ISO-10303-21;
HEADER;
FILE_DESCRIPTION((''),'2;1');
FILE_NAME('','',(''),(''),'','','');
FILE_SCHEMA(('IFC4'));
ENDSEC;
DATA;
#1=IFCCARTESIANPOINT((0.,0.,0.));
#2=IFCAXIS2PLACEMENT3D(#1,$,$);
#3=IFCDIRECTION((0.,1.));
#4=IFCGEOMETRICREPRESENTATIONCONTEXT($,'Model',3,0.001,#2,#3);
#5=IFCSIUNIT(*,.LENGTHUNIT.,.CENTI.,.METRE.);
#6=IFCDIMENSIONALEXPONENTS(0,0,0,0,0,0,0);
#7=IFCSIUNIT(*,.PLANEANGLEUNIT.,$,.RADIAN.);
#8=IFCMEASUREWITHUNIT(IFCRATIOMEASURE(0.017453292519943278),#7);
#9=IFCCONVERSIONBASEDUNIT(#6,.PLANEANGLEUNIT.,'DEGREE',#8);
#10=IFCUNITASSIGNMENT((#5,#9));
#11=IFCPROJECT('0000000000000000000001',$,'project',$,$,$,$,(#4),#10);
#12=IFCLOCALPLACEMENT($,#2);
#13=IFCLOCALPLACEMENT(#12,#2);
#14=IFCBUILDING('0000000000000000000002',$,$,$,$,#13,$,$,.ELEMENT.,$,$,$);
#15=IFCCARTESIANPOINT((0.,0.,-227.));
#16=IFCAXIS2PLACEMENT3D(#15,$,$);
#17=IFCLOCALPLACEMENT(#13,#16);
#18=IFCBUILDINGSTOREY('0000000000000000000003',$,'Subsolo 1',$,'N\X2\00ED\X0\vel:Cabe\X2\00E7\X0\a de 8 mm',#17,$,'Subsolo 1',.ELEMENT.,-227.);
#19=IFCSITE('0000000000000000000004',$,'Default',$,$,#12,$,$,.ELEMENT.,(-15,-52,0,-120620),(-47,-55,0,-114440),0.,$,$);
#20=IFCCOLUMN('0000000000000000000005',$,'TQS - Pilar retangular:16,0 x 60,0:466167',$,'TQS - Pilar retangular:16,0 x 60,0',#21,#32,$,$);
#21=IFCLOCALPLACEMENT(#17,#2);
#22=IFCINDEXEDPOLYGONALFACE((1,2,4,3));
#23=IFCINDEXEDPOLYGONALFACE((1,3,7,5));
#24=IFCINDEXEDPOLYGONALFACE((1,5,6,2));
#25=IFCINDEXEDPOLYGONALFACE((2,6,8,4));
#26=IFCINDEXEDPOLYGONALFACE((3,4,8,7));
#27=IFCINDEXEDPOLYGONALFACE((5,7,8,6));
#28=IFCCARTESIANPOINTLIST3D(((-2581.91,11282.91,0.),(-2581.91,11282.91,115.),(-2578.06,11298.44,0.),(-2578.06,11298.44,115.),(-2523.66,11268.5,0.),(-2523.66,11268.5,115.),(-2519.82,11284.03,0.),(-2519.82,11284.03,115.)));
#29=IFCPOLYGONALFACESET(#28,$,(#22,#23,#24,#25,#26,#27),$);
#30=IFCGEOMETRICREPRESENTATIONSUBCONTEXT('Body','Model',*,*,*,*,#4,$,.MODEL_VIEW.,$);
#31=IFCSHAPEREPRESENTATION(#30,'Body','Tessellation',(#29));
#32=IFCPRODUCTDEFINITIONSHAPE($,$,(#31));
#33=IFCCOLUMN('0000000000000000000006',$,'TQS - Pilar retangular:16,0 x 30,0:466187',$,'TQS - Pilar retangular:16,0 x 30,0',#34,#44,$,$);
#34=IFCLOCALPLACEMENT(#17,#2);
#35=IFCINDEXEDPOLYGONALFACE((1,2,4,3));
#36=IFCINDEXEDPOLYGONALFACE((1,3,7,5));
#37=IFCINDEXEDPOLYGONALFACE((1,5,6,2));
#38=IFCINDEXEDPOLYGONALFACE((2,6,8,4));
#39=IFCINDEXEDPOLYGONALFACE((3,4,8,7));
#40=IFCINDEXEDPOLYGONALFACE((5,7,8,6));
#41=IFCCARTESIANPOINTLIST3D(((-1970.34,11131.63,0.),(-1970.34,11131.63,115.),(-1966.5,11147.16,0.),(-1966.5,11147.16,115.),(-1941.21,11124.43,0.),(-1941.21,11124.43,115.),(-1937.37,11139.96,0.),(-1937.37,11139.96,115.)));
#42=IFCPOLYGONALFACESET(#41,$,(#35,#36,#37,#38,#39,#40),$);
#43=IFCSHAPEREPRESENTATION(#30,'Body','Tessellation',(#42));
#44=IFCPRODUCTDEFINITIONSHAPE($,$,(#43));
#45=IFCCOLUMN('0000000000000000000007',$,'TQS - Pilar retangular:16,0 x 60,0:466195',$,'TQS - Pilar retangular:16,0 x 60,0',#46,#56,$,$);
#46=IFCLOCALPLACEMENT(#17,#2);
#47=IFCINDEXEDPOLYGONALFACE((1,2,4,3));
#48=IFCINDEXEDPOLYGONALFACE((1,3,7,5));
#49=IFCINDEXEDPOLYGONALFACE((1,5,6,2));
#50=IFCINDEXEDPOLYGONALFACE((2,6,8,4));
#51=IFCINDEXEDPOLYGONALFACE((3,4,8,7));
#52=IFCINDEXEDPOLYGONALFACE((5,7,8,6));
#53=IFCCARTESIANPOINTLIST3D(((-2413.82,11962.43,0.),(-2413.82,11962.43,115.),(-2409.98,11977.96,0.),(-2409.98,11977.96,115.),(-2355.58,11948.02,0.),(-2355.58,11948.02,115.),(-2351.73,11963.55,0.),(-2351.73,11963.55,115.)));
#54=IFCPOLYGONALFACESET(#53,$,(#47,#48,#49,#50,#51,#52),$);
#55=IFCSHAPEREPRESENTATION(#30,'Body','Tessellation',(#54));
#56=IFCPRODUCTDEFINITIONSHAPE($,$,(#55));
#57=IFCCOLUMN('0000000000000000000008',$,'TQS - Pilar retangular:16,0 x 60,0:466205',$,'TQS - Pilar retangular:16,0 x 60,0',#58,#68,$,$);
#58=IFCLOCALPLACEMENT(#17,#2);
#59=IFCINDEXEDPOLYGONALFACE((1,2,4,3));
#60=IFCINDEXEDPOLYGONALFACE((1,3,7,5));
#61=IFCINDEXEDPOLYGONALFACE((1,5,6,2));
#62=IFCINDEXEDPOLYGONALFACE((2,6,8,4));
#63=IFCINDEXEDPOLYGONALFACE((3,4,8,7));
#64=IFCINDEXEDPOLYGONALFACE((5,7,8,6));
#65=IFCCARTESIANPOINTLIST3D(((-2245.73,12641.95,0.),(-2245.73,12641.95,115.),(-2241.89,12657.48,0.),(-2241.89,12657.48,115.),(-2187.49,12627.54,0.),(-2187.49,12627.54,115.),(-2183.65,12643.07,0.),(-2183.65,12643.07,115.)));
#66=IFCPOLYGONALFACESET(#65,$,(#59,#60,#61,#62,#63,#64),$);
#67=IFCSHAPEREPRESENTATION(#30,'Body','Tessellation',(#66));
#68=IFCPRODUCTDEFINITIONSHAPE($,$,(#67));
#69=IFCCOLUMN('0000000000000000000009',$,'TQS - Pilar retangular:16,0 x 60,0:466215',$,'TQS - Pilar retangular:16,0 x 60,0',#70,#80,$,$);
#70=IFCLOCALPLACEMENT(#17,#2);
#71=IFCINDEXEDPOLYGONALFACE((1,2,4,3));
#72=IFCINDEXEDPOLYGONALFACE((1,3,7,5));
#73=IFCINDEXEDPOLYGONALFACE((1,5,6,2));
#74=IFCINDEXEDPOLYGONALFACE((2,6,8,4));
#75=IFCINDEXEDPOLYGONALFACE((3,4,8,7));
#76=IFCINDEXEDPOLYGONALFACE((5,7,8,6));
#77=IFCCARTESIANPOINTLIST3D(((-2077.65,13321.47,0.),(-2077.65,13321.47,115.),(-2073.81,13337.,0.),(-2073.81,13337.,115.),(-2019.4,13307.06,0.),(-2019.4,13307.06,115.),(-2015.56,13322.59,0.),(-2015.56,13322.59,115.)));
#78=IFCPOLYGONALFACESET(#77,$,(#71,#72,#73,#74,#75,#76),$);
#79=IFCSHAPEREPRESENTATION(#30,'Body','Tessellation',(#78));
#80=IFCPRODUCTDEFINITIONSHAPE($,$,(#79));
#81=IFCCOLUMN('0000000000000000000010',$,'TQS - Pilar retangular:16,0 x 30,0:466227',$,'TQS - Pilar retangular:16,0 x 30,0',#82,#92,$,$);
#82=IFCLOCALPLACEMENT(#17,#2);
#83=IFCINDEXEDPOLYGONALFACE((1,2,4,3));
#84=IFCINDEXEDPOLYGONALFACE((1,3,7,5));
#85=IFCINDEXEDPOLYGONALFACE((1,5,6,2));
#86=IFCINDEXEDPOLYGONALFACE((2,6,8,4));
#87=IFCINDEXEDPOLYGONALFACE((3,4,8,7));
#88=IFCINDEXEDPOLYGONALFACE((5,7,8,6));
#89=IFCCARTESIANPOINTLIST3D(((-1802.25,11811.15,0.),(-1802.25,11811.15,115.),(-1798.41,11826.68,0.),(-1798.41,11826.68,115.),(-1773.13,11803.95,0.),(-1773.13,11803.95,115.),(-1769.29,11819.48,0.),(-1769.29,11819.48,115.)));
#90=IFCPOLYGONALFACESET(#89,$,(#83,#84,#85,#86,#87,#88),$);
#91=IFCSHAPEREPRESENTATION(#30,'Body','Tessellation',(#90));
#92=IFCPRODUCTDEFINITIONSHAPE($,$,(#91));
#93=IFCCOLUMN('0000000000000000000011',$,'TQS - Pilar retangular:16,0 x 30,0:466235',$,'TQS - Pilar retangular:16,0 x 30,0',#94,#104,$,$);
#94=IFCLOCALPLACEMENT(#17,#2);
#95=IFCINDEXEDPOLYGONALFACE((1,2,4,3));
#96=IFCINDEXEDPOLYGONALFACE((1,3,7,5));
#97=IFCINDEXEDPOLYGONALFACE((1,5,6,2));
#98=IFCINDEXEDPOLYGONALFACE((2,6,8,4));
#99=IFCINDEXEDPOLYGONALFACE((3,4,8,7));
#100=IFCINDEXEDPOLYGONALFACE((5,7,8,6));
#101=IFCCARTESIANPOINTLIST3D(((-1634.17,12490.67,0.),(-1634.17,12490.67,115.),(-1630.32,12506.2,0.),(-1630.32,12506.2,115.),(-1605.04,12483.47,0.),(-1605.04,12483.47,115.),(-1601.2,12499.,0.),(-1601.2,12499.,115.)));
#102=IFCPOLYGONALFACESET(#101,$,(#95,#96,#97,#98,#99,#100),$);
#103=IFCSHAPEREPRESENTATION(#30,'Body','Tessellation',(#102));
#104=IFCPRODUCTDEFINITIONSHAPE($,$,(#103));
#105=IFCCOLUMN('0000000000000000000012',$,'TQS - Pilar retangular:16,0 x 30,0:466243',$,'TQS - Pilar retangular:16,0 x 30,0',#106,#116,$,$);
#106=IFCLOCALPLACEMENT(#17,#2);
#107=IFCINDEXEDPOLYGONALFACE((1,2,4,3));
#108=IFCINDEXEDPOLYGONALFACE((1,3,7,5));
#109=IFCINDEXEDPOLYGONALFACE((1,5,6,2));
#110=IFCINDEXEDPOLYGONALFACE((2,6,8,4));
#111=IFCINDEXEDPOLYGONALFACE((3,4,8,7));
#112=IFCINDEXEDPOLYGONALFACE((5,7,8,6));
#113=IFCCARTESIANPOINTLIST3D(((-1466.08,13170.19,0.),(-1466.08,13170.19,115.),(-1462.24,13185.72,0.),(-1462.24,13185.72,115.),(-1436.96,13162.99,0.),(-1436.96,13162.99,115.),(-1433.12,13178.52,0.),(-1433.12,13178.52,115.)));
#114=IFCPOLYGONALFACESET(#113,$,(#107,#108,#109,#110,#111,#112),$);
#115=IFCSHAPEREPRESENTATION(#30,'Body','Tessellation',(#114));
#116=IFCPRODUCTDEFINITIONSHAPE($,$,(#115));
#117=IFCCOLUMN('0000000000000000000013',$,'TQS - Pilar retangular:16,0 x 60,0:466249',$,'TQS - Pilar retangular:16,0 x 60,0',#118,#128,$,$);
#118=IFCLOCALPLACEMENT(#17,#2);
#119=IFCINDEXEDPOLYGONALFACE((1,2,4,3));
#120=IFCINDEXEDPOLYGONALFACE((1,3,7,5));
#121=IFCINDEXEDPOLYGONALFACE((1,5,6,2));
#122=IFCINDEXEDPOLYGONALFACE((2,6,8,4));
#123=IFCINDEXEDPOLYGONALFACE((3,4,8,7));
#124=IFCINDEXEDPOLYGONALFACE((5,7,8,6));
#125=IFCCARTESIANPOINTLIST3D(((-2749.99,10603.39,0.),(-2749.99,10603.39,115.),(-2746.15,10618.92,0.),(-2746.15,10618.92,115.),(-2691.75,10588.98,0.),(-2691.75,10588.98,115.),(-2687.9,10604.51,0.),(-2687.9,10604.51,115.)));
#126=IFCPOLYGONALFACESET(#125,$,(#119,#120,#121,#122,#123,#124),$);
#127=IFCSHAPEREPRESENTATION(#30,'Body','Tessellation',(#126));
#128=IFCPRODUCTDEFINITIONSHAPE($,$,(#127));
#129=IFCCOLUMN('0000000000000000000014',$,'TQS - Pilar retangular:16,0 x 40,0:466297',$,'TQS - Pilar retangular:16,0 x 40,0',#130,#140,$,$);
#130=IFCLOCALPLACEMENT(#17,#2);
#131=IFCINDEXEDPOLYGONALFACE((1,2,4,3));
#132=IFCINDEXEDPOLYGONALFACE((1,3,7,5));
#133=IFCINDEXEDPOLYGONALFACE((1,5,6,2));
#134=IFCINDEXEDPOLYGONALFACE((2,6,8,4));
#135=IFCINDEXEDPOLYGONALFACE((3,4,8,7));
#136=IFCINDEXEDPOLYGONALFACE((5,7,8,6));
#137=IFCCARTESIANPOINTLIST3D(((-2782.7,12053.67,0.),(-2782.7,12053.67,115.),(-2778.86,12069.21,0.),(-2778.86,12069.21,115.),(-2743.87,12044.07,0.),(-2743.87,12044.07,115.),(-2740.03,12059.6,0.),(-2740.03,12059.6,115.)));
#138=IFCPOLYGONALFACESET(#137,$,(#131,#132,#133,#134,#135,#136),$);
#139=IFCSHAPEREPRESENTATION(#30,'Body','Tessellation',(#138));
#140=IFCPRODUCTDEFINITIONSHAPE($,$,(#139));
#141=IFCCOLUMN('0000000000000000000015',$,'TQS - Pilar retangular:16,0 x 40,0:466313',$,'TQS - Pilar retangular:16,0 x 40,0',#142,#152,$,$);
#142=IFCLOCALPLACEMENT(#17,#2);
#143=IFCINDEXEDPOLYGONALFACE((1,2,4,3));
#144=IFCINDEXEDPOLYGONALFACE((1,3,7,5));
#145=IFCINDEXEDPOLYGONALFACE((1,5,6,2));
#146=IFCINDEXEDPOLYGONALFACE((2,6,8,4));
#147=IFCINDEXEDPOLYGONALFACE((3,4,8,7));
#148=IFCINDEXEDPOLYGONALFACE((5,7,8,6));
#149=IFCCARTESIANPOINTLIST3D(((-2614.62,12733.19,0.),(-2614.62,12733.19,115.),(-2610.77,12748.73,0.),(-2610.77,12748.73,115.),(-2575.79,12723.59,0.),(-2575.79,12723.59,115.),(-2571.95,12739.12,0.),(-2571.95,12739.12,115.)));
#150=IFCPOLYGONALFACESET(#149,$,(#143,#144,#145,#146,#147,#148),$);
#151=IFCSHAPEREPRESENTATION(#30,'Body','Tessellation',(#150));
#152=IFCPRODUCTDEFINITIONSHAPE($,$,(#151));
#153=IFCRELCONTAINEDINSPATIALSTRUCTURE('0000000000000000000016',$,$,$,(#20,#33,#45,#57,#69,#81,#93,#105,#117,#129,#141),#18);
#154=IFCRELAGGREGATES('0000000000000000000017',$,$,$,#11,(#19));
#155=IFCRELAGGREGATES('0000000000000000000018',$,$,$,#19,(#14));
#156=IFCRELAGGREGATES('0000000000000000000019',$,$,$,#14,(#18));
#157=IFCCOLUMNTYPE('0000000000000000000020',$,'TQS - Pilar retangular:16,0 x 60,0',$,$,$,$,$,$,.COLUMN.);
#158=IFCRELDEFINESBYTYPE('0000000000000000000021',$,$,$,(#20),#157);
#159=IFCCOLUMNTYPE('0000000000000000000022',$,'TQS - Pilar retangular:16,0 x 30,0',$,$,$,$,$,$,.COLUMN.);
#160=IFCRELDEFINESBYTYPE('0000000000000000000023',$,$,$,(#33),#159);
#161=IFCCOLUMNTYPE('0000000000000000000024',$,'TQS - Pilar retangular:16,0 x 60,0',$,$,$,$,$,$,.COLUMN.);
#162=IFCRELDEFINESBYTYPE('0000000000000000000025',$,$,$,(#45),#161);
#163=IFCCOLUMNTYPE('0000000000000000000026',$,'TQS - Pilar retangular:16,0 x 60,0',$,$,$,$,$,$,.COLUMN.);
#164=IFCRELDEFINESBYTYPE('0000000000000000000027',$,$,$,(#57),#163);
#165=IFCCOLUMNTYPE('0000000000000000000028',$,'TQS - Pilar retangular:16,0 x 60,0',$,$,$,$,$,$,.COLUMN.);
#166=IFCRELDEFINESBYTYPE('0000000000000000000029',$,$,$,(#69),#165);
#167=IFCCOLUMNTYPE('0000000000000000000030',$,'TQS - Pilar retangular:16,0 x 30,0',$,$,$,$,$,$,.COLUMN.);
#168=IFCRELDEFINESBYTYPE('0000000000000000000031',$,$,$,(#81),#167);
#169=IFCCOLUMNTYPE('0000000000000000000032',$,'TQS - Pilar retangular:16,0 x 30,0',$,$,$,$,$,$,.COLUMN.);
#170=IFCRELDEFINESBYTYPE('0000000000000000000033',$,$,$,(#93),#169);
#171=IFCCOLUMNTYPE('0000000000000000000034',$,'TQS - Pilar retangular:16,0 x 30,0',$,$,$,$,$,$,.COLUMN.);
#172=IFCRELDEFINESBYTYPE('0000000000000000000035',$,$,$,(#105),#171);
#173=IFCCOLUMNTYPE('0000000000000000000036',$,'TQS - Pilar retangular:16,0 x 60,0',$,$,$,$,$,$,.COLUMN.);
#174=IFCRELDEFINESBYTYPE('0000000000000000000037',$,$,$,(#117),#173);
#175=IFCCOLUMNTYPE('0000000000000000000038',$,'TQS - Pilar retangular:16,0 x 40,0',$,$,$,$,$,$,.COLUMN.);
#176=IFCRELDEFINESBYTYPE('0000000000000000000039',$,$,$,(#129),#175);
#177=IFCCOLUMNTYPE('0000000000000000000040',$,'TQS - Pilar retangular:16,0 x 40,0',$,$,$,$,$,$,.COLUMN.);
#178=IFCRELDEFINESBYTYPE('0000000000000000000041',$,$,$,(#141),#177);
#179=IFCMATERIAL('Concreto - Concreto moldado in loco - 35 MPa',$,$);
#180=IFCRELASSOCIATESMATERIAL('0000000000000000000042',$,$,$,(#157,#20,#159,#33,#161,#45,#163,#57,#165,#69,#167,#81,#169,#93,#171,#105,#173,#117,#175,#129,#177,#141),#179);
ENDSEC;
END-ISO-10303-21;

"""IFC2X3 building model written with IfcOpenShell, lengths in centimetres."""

from ifc_helpers import new_model, entity, si_unit, converted_unit, direction, frame, frame_2d, origin, origin_2d_with_axis, place, context, subcontext, project, spatial, rectangle, extrude, source, transform, mapped, material, type_object, type_shapes, element, save


model = new_model("IFC2X3")

# Units and contexts
model_context = context("Model", 3, precision=0.001, world=origin(), true_north=direction((0.0, 1.0)))
body_context = subcontext(model_context, "Body", "Model", "MODEL_VIEW")
ifc_project = project(units=[si_unit("LENGTHUNIT", "METRE", prefix="CENTI"), converted_unit("PLANEANGLEUNIT", "DEGREE", entity("IfcRatioMeasure", 0.017453292519943278), si_unit("PLANEANGLEUNIT", "RADIAN"), dimensions=[0, 0, 0, 0, 0, 0, 0])], contexts=[model_context])

# Site, building, storey
site_placement = place(None, origin())
site = spatial("IfcSite", under=ifc_project, at=site_placement, Name="Default", CompositionType="ELEMENT", RefLatitude=(-15, -52, 0, -120620), RefLongitude=(-47, -55, 0, -114440), RefElevation=0.0)
building_placement = place(site_placement, origin())
building = spatial("IfcBuilding", under=site, at=building_placement, CompositionType="ELEMENT")
storey_placement = place(building_placement, frame((0.0, 0.0, -227.0)))
storey = spatial("IfcBuildingStorey", under=building, at=storey_placement, Name="Subsolo 1", ObjectType="Nível:Cabeça de 8 mm", LongName="Subsolo 1", CompositionType="ELEMENT", Elevation=-227.0)

# Columns
ifc_material = material(Name="Concreto - Concreto moldado in loco - 35 MPa")
column_type_1 = type_object("IfcColumnType", Name="TQS - Pilar retangular:16,0 x 60,0", PredefinedType="COLUMN", material=ifc_material)
shared_shape_1 = source(origin(), body_context, "Body", "SweptSolid", [
    extrude(rectangle(XDim=60.0, YDim=16.0, at=origin_2d_with_axis()), frame((-2550.86, 11283.47, -227.0), z_axis=(0.0, 0.0, 1.0), x_axis=(-0.970743, 0.240122, 0.0)), (0.0, 0.0, 1.0), 115.0),
])
type_shapes(column_type_1, [shared_shape_1])
column_1_placement = place(storey_placement, frame((0.0, 0.0, 227.0)))
element("IfcColumn", 1, at=column_1_placement, inside=storey, type_object=column_type_1, material=ifc_material, Name="TQS - Pilar retangular:16,0 x 60,0:466167", ObjectType="TQS - Pilar retangular:16,0 x 60,0", context=body_context, shape_type="MappedRepresentation", body=[
    mapped(shared_shape_1, transform((0.0, 0.0, 0.0), scale=1.0)),
])
column_type_2 = type_object("IfcColumnType", Name="TQS - Pilar retangular:16,0 x 30,0", PredefinedType="COLUMN", material=ifc_material)
shared_shape_2 = source(origin(), body_context, "Body", "SweptSolid", [
    extrude(rectangle(XDim=30.0, YDim=16.0, at=frame_2d((0.0, 0.0), x_axis=(1.0, 0.0))), frame((-1953.86, 11135.79, -227.0), z_axis=(0.0, 0.0, 1.0), x_axis=(-0.970743, 0.240122, 0.0)), (0.0, 0.0, 1.0), 115.0),
])
type_shapes(column_type_2, [shared_shape_2])
column_2_placement = place(storey_placement, frame((0.0, 0.0, 227.0)))
element("IfcColumn", 2, at=column_2_placement, inside=storey, type_object=column_type_2, material=ifc_material, Name="TQS - Pilar retangular:16,0 x 30,0:466187", ObjectType="TQS - Pilar retangular:16,0 x 30,0", context=body_context, shape_type="MappedRepresentation", body=[
    mapped(shared_shape_2, transform((0.0, 0.0, 0.0), scale=1.0)),
])
column_type_3 = type_object("IfcColumnType", Name="TQS - Pilar retangular:16,0 x 60,0", PredefinedType="COLUMN", material=ifc_material)
shared_shape_3 = source(origin(), body_context, "Body", "SweptSolid", [
    extrude(rectangle(XDim=60.0, YDim=16.0, at=origin_2d_with_axis()), frame((-2382.78, 11962.99, -227.0), z_axis=(0.0, 0.0, 1.0), x_axis=(-0.970743, 0.240122, 0.0)), (0.0, 0.0, 1.0), 115.0),
])
type_shapes(column_type_3, [shared_shape_3])
column_3_placement = place(storey_placement, frame((0.0, 0.0, 227.0)))
element("IfcColumn", 3, at=column_3_placement, inside=storey, type_object=column_type_3, material=ifc_material, Name="TQS - Pilar retangular:16,0 x 60,0:466195", ObjectType="TQS - Pilar retangular:16,0 x 60,0", context=body_context, shape_type="MappedRepresentation", body=[
    mapped(shared_shape_3, transform((0.0, 0.0, 0.0), scale=1.0)),
])
column_type_4 = type_object("IfcColumnType", Name="TQS - Pilar retangular:16,0 x 60,0", PredefinedType="COLUMN", material=ifc_material)
shared_shape_4 = source(origin(), body_context, "Body", "SweptSolid", [
    extrude(rectangle(XDim=60.0, YDim=16.0, at=origin_2d_with_axis()), frame((-2214.69, 12642.51, -227.0), z_axis=(0.0, 0.0, 1.0), x_axis=(-0.970743, 0.240122, 0.0)), (0.0, 0.0, 1.0), 115.0),
])
type_shapes(column_type_4, [shared_shape_4])
column_4_placement = place(storey_placement, frame((0.0, 0.0, 227.0)))
element("IfcColumn", 4, at=column_4_placement, inside=storey, type_object=column_type_4, material=ifc_material, Name="TQS - Pilar retangular:16,0 x 60,0:466205", ObjectType="TQS - Pilar retangular:16,0 x 60,0", context=body_context, shape_type="MappedRepresentation", body=[
    mapped(shared_shape_4, transform((0.0, 0.0, 0.0), scale=1.0)),
])
column_type_5 = type_object("IfcColumnType", Name="TQS - Pilar retangular:16,0 x 60,0", PredefinedType="COLUMN", material=ifc_material)
shared_shape_5 = source(origin(), body_context, "Body", "SweptSolid", [
    extrude(rectangle(XDim=60.0, YDim=16.0, at=origin_2d_with_axis()), frame((-2046.61, 13322.03, -227.0), z_axis=(0.0, 0.0, 1.0), x_axis=(-0.970743, 0.240122, 0.0)), (0.0, 0.0, 1.0), 115.0),
])
type_shapes(column_type_5, [shared_shape_5])
column_5_placement = place(storey_placement, frame((0.0, 0.0, 227.0)))
element("IfcColumn", 5, at=column_5_placement, inside=storey, type_object=column_type_5, material=ifc_material, Name="TQS - Pilar retangular:16,0 x 60,0:466215", ObjectType="TQS - Pilar retangular:16,0 x 60,0", context=body_context, shape_type="MappedRepresentation", body=[
    mapped(shared_shape_5, transform((0.0, 0.0, 0.0), scale=1.0)),
])
column_type_6 = type_object("IfcColumnType", Name="TQS - Pilar retangular:16,0 x 30,0", PredefinedType="COLUMN", material=ifc_material)
shared_shape_6 = source(origin(), body_context, "Body", "SweptSolid", [
    extrude(rectangle(XDim=30.0, YDim=16.0, at=origin_2d_with_axis()), frame((-1785.77, 11815.31, -227.0), z_axis=(0.0, 0.0, 1.0), x_axis=(-0.970743, 0.240122, 0.0)), (0.0, 0.0, 1.0), 115.0),
])
type_shapes(column_type_6, [shared_shape_6])
column_6_placement = place(storey_placement, frame((0.0, 0.0, 227.0)))
element("IfcColumn", 6, at=column_6_placement, inside=storey, type_object=column_type_6, material=ifc_material, Name="TQS - Pilar retangular:16,0 x 30,0:466227", ObjectType="TQS - Pilar retangular:16,0 x 30,0", context=body_context, shape_type="MappedRepresentation", body=[
    mapped(shared_shape_6, transform((0.0, 0.0, 0.0), scale=1.0)),
])
column_type_7 = type_object("IfcColumnType", Name="TQS - Pilar retangular:16,0 x 30,0", PredefinedType="COLUMN", material=ifc_material)
shared_shape_7 = source(origin(), body_context, "Body", "SweptSolid", [
    extrude(rectangle(XDim=30.0, YDim=16.0, at=origin_2d_with_axis()), frame((0.0, 0.0, -227.0), z_axis=(0.0, 0.0, 1.0), x_axis=(0.0, -1.0, 0.0)), (0.0, 0.0, 1.0), 115.0),
])
type_shapes(column_type_7, [shared_shape_7])
column_7_placement = place(storey_placement, frame((-1617.68, 12494.83, 227.0), z_axis=(0.0, 0.0, 1.0), x_axis=(0.240122, 0.970743, 0.0)))
element("IfcColumn", 7, at=column_7_placement, inside=storey, type_object=column_type_7, material=ifc_material, Name="TQS - Pilar retangular:16,0 x 30,0:466235", ObjectType="TQS - Pilar retangular:16,0 x 30,0", context=body_context, shape_type="MappedRepresentation", body=[
    mapped(shared_shape_7, transform((0.0, 0.0, 0.0), scale=1.0)),
])
column_type_8 = type_object("IfcColumnType", Name="TQS - Pilar retangular:16,0 x 30,0", PredefinedType="COLUMN", material=ifc_material)
shared_shape_8 = source(origin(), body_context, "Body", "SweptSolid", [
    extrude(rectangle(XDim=30.0, YDim=16.0, at=origin_2d_with_axis()), frame((-1449.6, 13174.35, -227.0), z_axis=(0.0, 0.0, 1.0), x_axis=(-0.970743, 0.240122, 0.0)), (0.0, 0.0, 1.0), 115.0),
])
type_shapes(column_type_8, [shared_shape_8])
column_8_placement = place(storey_placement, frame((0.0, 0.0, 227.0)))
element("IfcColumn", 8, at=column_8_placement, inside=storey, type_object=column_type_8, material=ifc_material, Name="TQS - Pilar retangular:16,0 x 30,0:466243", ObjectType="TQS - Pilar retangular:16,0 x 30,0", context=body_context, shape_type="MappedRepresentation", body=[
    mapped(shared_shape_8, transform((0.0, 0.0, 0.0), scale=1.0)),
])
column_type_9 = type_object("IfcColumnType", Name="TQS - Pilar retangular:16,0 x 60,0", PredefinedType="COLUMN", material=ifc_material)
shared_shape_9 = source(origin(), body_context, "Body", "SweptSolid", [
    extrude(rectangle(XDim=60.0, YDim=16.0, at=origin_2d_with_axis()), frame((-2718.95, 10603.95, -227.0), z_axis=(0.0, 0.0, 1.0), x_axis=(-0.970743, 0.240122, 0.0)), (0.0, 0.0, 1.0), 115.0),
])
type_shapes(column_type_9, [shared_shape_9])
column_9_placement = place(storey_placement, frame((0.0, 0.0, 227.0)))
element("IfcColumn", 9, at=column_9_placement, inside=storey, type_object=column_type_9, material=ifc_material, Name="TQS - Pilar retangular:16,0 x 60,0:466249", ObjectType="TQS - Pilar retangular:16,0 x 60,0", context=body_context, shape_type="MappedRepresentation", body=[
    mapped(shared_shape_9, transform((0.0, 0.0, 0.0), scale=1.0)),
])
column_type_10 = type_object("IfcColumnType", Name="TQS - Pilar retangular:16,0 x 40,0", PredefinedType="COLUMN", material=ifc_material)
shared_shape_10 = source(origin(), body_context, "Body", "SweptSolid", [
    extrude(rectangle(XDim=40.0, YDim=16.0, at=origin_2d_with_axis()), frame((-2761.37, 12056.64, -227.0), z_axis=(0.0, 0.0, 1.0), x_axis=(-0.970743, 0.240122, 0.0)), (0.0, 0.0, 1.0), 115.0),
])
type_shapes(column_type_10, [shared_shape_10])
column_10_placement = place(storey_placement, frame((0.0, 0.0, 227.0)))
element("IfcColumn", 10, at=column_10_placement, inside=storey, type_object=column_type_10, material=ifc_material, Name="TQS - Pilar retangular:16,0 x 40,0:466297", ObjectType="TQS - Pilar retangular:16,0 x 40,0", context=body_context, shape_type="MappedRepresentation", body=[
    mapped(shared_shape_10, transform((0.0, 0.0, 0.0), scale=1.0)),
])
column_type_11 = type_object("IfcColumnType", Name="TQS - Pilar retangular:16,0 x 40,0", PredefinedType="COLUMN", material=ifc_material)
shared_shape_11 = source(origin(), body_context, "Body", "SweptSolid", [
    extrude(rectangle(XDim=40.0, YDim=16.0, at=origin_2d_with_axis()), frame((-2593.28, 12736.16, -227.0), z_axis=(0.0, 0.0, 1.0), x_axis=(-0.970743, 0.240122, 0.0)), (0.0, 0.0, 1.0), 115.0),
])
type_shapes(column_type_11, [shared_shape_11])
column_11_placement = place(storey_placement, frame((0.0, 0.0, 227.0)))
element("IfcColumn", 11, at=column_11_placement, inside=storey, type_object=column_type_11, material=ifc_material, Name="TQS - Pilar retangular:16,0 x 40,0:466313", ObjectType="TQS - Pilar retangular:16,0 x 40,0", context=body_context, shape_type="MappedRepresentation", body=[
    mapped(shared_shape_11, transform((0.0, 0.0, 0.0), scale=1.0)),
])

save(model, "model.ifc")
